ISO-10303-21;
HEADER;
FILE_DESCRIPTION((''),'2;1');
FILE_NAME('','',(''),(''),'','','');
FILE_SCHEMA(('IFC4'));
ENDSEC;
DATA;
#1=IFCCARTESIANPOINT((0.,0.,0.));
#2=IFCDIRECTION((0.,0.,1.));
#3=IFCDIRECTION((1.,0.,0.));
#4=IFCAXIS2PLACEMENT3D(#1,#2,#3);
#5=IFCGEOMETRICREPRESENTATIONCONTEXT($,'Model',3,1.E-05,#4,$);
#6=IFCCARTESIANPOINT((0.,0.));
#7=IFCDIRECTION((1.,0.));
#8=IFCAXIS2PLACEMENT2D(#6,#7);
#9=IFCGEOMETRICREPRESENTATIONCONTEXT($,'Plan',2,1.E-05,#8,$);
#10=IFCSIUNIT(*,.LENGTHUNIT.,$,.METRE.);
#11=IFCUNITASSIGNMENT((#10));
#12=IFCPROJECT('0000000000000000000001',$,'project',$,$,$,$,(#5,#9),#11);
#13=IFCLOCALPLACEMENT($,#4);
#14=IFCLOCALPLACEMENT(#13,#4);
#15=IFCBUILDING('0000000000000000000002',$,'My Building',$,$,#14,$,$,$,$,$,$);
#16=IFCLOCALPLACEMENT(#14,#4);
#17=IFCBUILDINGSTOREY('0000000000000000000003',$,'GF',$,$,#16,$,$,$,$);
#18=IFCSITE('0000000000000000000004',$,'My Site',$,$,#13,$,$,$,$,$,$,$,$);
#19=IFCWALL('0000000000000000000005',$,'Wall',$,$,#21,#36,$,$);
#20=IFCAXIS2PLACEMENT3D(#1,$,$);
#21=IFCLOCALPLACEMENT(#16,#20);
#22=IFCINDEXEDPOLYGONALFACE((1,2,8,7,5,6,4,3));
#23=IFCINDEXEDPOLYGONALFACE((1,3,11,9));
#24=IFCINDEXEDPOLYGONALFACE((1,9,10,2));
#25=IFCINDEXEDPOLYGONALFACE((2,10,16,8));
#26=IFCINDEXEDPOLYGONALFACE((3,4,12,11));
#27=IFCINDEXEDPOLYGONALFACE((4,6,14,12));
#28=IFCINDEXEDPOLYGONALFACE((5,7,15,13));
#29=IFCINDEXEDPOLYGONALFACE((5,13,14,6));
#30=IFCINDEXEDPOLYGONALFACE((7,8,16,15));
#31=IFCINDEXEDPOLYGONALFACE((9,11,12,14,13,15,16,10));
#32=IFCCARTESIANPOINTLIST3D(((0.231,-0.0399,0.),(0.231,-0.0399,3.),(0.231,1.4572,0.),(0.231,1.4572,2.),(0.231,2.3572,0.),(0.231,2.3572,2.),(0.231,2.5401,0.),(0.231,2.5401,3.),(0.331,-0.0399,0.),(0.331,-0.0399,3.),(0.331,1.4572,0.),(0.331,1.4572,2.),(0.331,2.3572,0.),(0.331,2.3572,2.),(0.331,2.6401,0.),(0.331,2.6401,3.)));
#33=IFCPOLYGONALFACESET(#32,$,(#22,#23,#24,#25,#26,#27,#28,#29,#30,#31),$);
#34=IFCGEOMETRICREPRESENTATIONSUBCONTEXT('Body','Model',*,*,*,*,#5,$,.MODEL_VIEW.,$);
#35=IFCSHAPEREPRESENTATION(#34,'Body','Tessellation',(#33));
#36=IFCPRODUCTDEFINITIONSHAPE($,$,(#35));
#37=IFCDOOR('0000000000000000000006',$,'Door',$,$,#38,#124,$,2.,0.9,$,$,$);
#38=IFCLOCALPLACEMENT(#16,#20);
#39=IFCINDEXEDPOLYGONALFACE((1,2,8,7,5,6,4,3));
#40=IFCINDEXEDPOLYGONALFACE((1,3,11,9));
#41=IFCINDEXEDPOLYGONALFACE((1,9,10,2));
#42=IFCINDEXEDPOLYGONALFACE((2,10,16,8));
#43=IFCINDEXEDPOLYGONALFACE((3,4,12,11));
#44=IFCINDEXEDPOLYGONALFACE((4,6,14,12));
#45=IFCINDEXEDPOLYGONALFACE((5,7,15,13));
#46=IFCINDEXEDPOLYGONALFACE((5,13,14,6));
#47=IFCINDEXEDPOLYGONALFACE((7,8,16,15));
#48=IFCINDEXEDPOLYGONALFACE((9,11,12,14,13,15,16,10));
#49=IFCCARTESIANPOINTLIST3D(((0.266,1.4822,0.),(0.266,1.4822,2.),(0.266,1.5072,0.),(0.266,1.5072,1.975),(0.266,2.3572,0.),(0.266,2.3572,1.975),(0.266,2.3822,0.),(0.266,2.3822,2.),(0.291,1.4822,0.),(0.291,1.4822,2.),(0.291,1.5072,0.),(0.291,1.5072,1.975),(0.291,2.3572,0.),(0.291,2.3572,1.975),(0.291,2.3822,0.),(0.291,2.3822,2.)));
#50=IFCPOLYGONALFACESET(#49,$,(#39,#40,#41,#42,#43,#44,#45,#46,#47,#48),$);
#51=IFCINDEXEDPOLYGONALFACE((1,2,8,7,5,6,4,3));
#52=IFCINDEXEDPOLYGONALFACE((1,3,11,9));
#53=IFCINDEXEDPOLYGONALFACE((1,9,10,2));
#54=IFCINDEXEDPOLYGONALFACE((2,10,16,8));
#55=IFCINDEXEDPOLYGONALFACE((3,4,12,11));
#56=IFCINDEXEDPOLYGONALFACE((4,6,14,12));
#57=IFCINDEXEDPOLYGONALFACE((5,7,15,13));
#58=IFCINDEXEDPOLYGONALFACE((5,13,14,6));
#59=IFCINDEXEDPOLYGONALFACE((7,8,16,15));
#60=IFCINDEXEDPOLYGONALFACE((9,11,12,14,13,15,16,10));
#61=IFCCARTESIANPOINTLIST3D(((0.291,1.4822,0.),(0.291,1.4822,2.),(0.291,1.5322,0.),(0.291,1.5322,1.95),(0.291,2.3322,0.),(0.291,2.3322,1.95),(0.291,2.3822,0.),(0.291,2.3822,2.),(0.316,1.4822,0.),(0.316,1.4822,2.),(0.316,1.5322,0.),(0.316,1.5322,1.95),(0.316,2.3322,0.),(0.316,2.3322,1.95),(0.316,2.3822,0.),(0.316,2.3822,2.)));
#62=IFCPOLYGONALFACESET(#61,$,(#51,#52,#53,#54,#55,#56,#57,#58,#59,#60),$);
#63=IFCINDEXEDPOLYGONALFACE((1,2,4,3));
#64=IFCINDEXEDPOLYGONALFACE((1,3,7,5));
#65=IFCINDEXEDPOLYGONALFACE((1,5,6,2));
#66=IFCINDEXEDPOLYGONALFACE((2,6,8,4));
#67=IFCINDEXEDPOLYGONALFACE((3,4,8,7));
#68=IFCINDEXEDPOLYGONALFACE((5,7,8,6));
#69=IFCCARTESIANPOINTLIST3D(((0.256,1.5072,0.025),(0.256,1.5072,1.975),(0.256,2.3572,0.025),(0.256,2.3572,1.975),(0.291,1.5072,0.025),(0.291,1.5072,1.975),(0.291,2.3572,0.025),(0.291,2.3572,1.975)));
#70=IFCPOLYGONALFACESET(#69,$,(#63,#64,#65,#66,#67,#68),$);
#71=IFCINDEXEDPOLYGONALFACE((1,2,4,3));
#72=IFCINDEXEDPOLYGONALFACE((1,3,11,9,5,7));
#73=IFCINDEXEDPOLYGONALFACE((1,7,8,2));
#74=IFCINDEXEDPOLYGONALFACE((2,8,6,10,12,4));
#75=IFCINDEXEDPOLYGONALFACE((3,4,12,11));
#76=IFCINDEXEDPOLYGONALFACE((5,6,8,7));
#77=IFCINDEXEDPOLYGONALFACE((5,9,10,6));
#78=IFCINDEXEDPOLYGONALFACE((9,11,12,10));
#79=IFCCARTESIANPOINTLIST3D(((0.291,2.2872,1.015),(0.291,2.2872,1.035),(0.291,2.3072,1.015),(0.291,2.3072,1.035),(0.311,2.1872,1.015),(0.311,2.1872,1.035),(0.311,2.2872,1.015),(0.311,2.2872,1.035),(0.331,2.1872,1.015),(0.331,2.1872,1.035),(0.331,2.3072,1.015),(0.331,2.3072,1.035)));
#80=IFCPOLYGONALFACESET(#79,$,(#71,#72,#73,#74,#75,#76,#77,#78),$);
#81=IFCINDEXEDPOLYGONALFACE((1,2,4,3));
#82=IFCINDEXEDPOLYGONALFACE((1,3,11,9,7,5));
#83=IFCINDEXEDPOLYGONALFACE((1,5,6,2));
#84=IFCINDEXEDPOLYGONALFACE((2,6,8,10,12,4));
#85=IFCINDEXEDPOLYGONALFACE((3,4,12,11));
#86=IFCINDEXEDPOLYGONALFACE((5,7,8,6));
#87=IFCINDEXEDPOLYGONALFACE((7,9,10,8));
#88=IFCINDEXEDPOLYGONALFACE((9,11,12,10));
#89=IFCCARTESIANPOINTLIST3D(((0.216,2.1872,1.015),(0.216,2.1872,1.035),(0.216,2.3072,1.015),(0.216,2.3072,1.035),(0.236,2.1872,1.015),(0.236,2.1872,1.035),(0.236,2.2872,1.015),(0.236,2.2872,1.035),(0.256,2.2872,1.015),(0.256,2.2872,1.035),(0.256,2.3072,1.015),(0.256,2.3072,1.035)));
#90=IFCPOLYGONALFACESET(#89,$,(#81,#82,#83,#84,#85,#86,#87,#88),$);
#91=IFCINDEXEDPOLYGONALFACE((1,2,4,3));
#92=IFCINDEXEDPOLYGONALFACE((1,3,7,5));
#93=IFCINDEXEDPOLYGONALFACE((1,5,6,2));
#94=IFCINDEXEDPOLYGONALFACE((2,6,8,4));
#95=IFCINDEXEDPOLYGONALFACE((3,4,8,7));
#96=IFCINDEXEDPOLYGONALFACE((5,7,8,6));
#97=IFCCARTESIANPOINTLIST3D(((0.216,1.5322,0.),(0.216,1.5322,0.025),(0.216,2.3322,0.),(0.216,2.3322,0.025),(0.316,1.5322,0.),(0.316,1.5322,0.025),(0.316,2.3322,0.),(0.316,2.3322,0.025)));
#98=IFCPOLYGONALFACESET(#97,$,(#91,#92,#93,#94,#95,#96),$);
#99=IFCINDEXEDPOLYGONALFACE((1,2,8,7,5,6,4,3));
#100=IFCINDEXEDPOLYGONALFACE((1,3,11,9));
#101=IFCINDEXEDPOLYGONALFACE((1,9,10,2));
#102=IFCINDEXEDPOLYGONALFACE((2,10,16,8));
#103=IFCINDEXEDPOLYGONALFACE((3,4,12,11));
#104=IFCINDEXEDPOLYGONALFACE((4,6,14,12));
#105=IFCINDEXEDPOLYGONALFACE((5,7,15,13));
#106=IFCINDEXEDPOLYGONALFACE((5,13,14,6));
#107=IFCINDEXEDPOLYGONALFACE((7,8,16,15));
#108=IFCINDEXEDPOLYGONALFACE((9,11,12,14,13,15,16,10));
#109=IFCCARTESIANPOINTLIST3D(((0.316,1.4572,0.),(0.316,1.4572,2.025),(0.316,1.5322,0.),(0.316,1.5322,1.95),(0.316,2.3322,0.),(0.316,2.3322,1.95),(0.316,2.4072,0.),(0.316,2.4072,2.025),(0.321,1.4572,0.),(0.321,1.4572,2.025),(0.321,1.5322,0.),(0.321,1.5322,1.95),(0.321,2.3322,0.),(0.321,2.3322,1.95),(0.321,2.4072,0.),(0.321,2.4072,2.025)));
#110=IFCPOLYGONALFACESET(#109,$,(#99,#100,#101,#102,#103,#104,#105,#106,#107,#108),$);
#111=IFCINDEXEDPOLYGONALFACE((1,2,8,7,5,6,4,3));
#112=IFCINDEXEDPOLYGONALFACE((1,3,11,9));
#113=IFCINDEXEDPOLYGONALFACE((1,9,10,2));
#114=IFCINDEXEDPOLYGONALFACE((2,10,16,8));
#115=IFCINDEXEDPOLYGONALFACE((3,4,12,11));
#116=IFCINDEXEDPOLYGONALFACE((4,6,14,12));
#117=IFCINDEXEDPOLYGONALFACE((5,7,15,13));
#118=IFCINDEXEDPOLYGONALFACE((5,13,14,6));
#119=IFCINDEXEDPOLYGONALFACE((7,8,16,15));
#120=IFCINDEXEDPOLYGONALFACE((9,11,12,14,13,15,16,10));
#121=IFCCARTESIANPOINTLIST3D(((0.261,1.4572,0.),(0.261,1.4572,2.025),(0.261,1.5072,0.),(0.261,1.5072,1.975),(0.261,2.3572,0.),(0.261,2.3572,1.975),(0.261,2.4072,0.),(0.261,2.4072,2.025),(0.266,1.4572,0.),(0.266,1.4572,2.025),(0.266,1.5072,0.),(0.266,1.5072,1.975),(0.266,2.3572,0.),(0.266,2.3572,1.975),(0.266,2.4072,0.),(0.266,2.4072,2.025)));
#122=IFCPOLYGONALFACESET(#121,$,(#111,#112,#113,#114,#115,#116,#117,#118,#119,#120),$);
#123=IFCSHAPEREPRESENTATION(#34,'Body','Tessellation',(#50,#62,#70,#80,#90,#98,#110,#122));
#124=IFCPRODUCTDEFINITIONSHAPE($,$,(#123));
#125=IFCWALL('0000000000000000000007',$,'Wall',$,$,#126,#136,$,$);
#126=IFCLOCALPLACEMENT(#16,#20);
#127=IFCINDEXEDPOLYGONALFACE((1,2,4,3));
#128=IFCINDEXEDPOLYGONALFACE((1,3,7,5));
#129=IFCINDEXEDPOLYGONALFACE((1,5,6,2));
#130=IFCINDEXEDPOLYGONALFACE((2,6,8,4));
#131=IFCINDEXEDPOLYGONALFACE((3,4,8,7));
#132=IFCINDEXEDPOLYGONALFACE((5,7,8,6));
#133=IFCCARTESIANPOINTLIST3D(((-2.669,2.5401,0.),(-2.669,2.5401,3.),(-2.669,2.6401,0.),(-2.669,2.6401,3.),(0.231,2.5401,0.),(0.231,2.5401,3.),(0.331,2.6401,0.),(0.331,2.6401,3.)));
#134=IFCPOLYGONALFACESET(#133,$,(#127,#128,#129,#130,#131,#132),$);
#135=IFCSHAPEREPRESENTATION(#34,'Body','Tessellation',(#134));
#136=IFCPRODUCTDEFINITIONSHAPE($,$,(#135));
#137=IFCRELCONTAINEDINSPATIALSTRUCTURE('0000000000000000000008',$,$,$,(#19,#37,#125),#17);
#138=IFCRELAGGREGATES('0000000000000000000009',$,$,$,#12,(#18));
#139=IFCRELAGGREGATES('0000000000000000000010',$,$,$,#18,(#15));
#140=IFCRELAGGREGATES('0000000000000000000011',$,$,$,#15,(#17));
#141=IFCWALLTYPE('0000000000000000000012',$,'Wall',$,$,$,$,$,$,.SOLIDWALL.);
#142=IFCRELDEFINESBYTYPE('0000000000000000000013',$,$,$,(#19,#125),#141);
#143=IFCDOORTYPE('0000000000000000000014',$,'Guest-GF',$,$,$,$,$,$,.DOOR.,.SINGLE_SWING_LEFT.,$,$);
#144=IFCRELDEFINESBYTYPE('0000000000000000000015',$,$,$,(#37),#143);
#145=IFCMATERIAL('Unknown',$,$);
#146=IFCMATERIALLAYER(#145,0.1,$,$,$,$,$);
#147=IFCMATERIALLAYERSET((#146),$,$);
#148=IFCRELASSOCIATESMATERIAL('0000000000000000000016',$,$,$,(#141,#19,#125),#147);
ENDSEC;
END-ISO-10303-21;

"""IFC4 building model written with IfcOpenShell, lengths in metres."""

from ifc_helpers import new_model, entity, si_unit, frame, origin_with_axes, origin_2d_with_axis, place, context, subcontext, project, spatial, line, indexed_curve, outline, extrude, shape, source, transform, mapped, material, layer, layer_set, layer_usage, type_object, type_shapes, element, fill, save


model = new_model("IFC4")

# Units and contexts
model_context = context("Model", 3, precision=1e-05, world=origin_with_axes())
plan_context = context("Plan", 2, precision=1e-05, world=origin_2d_with_axis())
body_context_1 = subcontext(model_context, "Body", "Model", "MODEL_VIEW")
body_context_2 = subcontext(plan_context, "Body", "Plan", "PLAN_VIEW")
ifc_project = project(units=[si_unit("LENGTHUNIT", "METRE")], contexts=[model_context, plan_context])

# Site, building, storey
site_placement = place(None, origin_with_axes())
site = spatial("IfcSite", under=ifc_project, at=site_placement, Name="My Site")
building_placement = place(site_placement, origin_with_axes())
building = spatial("IfcBuilding", under=site, at=building_placement, Name="My Building")
storey_placement = place(building_placement, origin_with_axes())
storey = spatial("IfcBuildingStorey", under=building, at=storey_placement, Name="GF")

# Shared definitions
ifc_material = material(Name="Unknown")

# Shared definitions
ifc_layer_1 = layer(ifc_material, 0.1)
ifc_layer_set_1 = layer_set([ifc_layer_1])
wall_type = type_object("IfcWallType", Name="Wall", PredefinedType="SOLIDWALL", material=ifc_layer_set_1)

# Wall, opening, door
ifc_layer_usage_1 = layer_usage(ifc_layer_set_1, "AXIS2", "POSITIVE", 0.0)
wall_1_placement = place(storey_placement, frame((0.331, -0.0399, 0.0), z_axis=(0.0, 0.0, 1.0), x_axis=(0.0, 1.0, 0.0)))
wall_1 = element("IfcWall", 1, at=wall_1_placement, inside=storey, type_object=wall_type, material=ifc_layer_usage_1, Name="Wall", context=body_context_1, shape_type="SweptSolid", body=[
    extrude(outline(indexed_curve([(0.0, 0.0), (0.0, 0.1), (2.58, 0.1), (2.68, 0.0)], segments=[line(1, 2, 3, 4, 1)])), origin_with_axes(), (0.0, 0.0, 1.0), 3.0),
])
shared_shape_1 = source(origin_with_axes(), body_context_1, "Body", "SweptSolid", [
    extrude(outline(indexed_curve([(0.0, 0.0), (0.9, 0.0), (0.9, 2.0), (0.0, 2.0)], segments=[line(1, 2, 3, 4, 1)])), frame((0.0, -0.6, 0.0), z_axis=(0.0, -1.0, 0.0), x_axis=(1.0, 0.0, 0.0)), (0.0, 0.0, -1.0), 1.2),
])
opening_1_placement = place(wall_1_placement, frame((1.4972, 0.0, 0.0), z_axis=(0.0, 0.0, 1.0), x_axis=(1.0, 0.0, 0.0)))
opening_1 = element("IfcOpeningElement", 2, at=opening_1_placement, cuts=wall_1, PredefinedType="OPENING", context=body_context_1, shape_type="MappedRepresentation", body=[
    mapped(shared_shape_1, transform((0.0, 0.0, 0.0), x_axis=(1.0, 0.0, 0.0), y_axis=(0.0, 1.0, 0.0), z_axis=(0.0, 0.0, 1.0), scale=1.0)),
])
door_type_1 = type_object("IfcDoorType", Name="Guest-GF", OperationType="SINGLE_SWING_LEFT", PredefinedType="DOOR")
shared_shape_2 = source(origin_with_axes(), body_context_1, "Body", "SweptSolid", [
    extrude(outline(indexed_curve([(0.0, 0.0), (0.0, 2.0), (0.9, 2.0), (0.9, 0.0), (0.875, 0.0), (0.875, 1.975), (0.025, 1.975), (0.025, 0.0)], segments=[line(1, 2, 3, 4, 5, 6, 7, 8, 1)])), frame((0.0, 0.025, 0.0), z_axis=(0.0, -1.0, 0.0), x_axis=(1.0, 0.0, 0.0)), (0.0, 0.0, -1.0), 0.025),
    extrude(outline(indexed_curve([(0.0, 0.0), (0.0, 2.0), (0.9, 2.0), (0.9, 0.0), (0.85, 0.0), (0.85, 1.95), (0.05, 1.95), (0.05, 0.0)], segments=[line(1, 2, 3, 4, 5, 6, 7, 8, 1)])), frame((0.0, 0.0, 0.0), z_axis=(0.0, -1.0, 0.0), x_axis=(1.0, 0.0, 0.0)), (0.0, 0.0, -1.0), 0.025),
    extrude(outline(indexed_curve([(0.0, 0.0), (0.85, 0.0), (0.85, 0.035), (0.0, 0.035)], segments=[line(1, 2, 3, 4, 1)])), frame((0.025, 0.025, 0.025), z_axis=(0.0, 0.0, 1.0), x_axis=(1.0, 0.0, 0.0)), (0.0, 0.0, 1.0), 1.95),
    extrude(outline(indexed_curve([(0.0, 0.0), (0.0, -0.04), (-0.12, -0.04), (-0.12, -0.02), (-0.02, -0.02), (-0.02, 0.0)], segments=[line(1, 2, 3, 4, 5, 6, 1)])), frame((0.825, 0.025, 1.015), z_axis=(0.0, 0.0, 1.0), x_axis=(1.0, 0.0, 0.0)), (0.0, 0.0, 1.0), 0.02),
    extrude(outline(indexed_curve([(0.0, 0.0), (0.0, 0.04), (-0.12, 0.04), (-0.12, 0.02), (-0.02, 0.02), (-0.02, 0.0)], segments=[line(1, 2, 3, 4, 5, 6, 1)])), frame((0.825, 0.06, 1.015), z_axis=(0.0, 0.0, 1.0), x_axis=(1.0, 0.0, 0.0)), (0.0, 0.0, 1.0), 0.02),
    extrude(outline(indexed_curve([(0.0, 0.0), (0.8, 0.0), (0.8, 0.1), (0.0, 0.1)], segments=[line(1, 2, 3, 4, 1)])), frame((0.05, 0.0, 0.0), z_axis=(0.0, 0.0, 1.0), x_axis=(1.0, 0.0, 0.0)), (0.0, 0.0, 1.0), 0.025),
    extrude(outline(indexed_curve([(0.0, 0.0), (0.0, 2.025), (0.95, 2.025), (0.95, 0.0), (0.875, 0.0), (0.875, 1.95), (0.075, 1.95), (0.075, 0.0)], segments=[line(1, 2, 3, 4, 5, 6, 7, 8, 1)])), frame((-0.025, -0.005, 0.0), z_axis=(0.0, -1.0, 0.0), x_axis=(1.0, 0.0, 0.0)), (0.0, 0.0, -1.0), 0.005),
    extrude(outline(indexed_curve([(0.0, 0.0), (0.0, 2.025), (0.95, 2.025), (0.95, 0.0), (0.9, 0.0), (0.9, 1.975), (0.05, 1.975), (0.05, 0.0)], segments=[line(1, 2, 3, 4, 5, 6, 7, 8, 1)])), frame((-0.025, 0.05, 0.0), z_axis=(0.0, -1.0, 0.0), x_axis=(1.0, 0.0, 0.0)), (0.0, 0.0, -1.0), 0.005),
])
shared_shape_3 = source(origin_with_axes(), body_context_2, "Body", "Curve2D", [
    entity("IfcIndexedPolyCurve", entity("IfcCartesianPointList2D", [[0.0, 0.0], [0.0, 0.05], [0.025, 0.05], [0.025, 0.025], [0.05, 0.025], [0.05, 0.0]]), [entity("IfcLineIndex", [1, 2, 3, 4, 5, 6, 1])]),
    entity("IfcIndexedPolyCurve", entity("IfcCartesianPointList2D", [[0.9, 0.0], [0.9, 0.05], [0.875, 0.05], [0.875, 0.025], [0.85, 0.025], [0.85, 0.0]]), [entity("IfcLineIndex", [1, 2, 3, 4, 5, 6, 1])]),
    entity("IfcTrimmedCurve", entity("IfcEllipse", entity("IfcAxis2Placement2D", entity("IfcCartesianPoint", [0.06, 0.05]), entity("IfcDirection", [1.0, 0.0])), 0.815, 0.85), [entity("IfcCartesianPoint", [0.875, 0.05])], [entity("IfcCartesianPoint", [0.06, 0.9])], True, "CARTESIAN"),
    entity("IfcIndexedPolyCurve", entity("IfcCartesianPointList2D", [[0.025, 0.05], [0.06, 0.05], [0.06, 0.9], [0.025, 0.9]]), [entity("IfcLineIndex", [1, 2, 3, 4, 1])]),
])
type_shapes(door_type_1, [shared_shape_2, shared_shape_3])
door_1_placement = place(opening_1_placement, frame((0.025, 0.015, 0.0), z_axis=(0.0, 0.0, 1.0), x_axis=(1.0, 0.0, 0.0)))
door_1 = element("IfcDoor", 3, at=door_1_placement, inside=storey, type_object=door_type_1, Name="Door", OverallHeight=2.0, OverallWidth=0.9, shapes=[
    shape(body_context_1, "Body", "MappedRepresentation", [mapped(shared_shape_2, transform((0.0, 0.0, 0.0), x_axis=(1.0, 0.0, 0.0), y_axis=(0.0, 1.0, 0.0), z_axis=(0.0, 0.0, 1.0), scale=1.0))]),
    shape(body_context_2, "Body", "MappedRepresentation", [mapped(shared_shape_3, transform((0.0, 0.0, 0.0), x_axis=(1.0, 0.0, 0.0), y_axis=(0.0, 1.0, 0.0), z_axis=(0.0, 0.0, 1.0), scale=1.0))]),
])
fill(opening_1, door_1)

# Wall
ifc_layer_usage_2 = layer_usage(ifc_layer_set_1, "AXIS2", "POSITIVE", 0.0)
wall_2_placement = place(storey_placement, frame((0.331, 2.6401, 0.0), z_axis=(0.0, 0.0, 1.0), x_axis=(-1.0, 0.0, 0.0)))
element("IfcWall", 4, at=wall_2_placement, inside=storey, type_object=wall_type, material=ifc_layer_usage_2, Name="Wall", context=body_context_1, shape_type="SweptSolid", body=[
    extrude(outline(indexed_curve([(0.0, 0.0), (0.1, 0.1), (3.0, 0.1), (3.0, 0.0)], segments=[line(1, 2, 3, 4, 1)])), origin_with_axes(), (0.0, 0.0, 1.0), 3.0),
])

save(model, "model.ifc")
